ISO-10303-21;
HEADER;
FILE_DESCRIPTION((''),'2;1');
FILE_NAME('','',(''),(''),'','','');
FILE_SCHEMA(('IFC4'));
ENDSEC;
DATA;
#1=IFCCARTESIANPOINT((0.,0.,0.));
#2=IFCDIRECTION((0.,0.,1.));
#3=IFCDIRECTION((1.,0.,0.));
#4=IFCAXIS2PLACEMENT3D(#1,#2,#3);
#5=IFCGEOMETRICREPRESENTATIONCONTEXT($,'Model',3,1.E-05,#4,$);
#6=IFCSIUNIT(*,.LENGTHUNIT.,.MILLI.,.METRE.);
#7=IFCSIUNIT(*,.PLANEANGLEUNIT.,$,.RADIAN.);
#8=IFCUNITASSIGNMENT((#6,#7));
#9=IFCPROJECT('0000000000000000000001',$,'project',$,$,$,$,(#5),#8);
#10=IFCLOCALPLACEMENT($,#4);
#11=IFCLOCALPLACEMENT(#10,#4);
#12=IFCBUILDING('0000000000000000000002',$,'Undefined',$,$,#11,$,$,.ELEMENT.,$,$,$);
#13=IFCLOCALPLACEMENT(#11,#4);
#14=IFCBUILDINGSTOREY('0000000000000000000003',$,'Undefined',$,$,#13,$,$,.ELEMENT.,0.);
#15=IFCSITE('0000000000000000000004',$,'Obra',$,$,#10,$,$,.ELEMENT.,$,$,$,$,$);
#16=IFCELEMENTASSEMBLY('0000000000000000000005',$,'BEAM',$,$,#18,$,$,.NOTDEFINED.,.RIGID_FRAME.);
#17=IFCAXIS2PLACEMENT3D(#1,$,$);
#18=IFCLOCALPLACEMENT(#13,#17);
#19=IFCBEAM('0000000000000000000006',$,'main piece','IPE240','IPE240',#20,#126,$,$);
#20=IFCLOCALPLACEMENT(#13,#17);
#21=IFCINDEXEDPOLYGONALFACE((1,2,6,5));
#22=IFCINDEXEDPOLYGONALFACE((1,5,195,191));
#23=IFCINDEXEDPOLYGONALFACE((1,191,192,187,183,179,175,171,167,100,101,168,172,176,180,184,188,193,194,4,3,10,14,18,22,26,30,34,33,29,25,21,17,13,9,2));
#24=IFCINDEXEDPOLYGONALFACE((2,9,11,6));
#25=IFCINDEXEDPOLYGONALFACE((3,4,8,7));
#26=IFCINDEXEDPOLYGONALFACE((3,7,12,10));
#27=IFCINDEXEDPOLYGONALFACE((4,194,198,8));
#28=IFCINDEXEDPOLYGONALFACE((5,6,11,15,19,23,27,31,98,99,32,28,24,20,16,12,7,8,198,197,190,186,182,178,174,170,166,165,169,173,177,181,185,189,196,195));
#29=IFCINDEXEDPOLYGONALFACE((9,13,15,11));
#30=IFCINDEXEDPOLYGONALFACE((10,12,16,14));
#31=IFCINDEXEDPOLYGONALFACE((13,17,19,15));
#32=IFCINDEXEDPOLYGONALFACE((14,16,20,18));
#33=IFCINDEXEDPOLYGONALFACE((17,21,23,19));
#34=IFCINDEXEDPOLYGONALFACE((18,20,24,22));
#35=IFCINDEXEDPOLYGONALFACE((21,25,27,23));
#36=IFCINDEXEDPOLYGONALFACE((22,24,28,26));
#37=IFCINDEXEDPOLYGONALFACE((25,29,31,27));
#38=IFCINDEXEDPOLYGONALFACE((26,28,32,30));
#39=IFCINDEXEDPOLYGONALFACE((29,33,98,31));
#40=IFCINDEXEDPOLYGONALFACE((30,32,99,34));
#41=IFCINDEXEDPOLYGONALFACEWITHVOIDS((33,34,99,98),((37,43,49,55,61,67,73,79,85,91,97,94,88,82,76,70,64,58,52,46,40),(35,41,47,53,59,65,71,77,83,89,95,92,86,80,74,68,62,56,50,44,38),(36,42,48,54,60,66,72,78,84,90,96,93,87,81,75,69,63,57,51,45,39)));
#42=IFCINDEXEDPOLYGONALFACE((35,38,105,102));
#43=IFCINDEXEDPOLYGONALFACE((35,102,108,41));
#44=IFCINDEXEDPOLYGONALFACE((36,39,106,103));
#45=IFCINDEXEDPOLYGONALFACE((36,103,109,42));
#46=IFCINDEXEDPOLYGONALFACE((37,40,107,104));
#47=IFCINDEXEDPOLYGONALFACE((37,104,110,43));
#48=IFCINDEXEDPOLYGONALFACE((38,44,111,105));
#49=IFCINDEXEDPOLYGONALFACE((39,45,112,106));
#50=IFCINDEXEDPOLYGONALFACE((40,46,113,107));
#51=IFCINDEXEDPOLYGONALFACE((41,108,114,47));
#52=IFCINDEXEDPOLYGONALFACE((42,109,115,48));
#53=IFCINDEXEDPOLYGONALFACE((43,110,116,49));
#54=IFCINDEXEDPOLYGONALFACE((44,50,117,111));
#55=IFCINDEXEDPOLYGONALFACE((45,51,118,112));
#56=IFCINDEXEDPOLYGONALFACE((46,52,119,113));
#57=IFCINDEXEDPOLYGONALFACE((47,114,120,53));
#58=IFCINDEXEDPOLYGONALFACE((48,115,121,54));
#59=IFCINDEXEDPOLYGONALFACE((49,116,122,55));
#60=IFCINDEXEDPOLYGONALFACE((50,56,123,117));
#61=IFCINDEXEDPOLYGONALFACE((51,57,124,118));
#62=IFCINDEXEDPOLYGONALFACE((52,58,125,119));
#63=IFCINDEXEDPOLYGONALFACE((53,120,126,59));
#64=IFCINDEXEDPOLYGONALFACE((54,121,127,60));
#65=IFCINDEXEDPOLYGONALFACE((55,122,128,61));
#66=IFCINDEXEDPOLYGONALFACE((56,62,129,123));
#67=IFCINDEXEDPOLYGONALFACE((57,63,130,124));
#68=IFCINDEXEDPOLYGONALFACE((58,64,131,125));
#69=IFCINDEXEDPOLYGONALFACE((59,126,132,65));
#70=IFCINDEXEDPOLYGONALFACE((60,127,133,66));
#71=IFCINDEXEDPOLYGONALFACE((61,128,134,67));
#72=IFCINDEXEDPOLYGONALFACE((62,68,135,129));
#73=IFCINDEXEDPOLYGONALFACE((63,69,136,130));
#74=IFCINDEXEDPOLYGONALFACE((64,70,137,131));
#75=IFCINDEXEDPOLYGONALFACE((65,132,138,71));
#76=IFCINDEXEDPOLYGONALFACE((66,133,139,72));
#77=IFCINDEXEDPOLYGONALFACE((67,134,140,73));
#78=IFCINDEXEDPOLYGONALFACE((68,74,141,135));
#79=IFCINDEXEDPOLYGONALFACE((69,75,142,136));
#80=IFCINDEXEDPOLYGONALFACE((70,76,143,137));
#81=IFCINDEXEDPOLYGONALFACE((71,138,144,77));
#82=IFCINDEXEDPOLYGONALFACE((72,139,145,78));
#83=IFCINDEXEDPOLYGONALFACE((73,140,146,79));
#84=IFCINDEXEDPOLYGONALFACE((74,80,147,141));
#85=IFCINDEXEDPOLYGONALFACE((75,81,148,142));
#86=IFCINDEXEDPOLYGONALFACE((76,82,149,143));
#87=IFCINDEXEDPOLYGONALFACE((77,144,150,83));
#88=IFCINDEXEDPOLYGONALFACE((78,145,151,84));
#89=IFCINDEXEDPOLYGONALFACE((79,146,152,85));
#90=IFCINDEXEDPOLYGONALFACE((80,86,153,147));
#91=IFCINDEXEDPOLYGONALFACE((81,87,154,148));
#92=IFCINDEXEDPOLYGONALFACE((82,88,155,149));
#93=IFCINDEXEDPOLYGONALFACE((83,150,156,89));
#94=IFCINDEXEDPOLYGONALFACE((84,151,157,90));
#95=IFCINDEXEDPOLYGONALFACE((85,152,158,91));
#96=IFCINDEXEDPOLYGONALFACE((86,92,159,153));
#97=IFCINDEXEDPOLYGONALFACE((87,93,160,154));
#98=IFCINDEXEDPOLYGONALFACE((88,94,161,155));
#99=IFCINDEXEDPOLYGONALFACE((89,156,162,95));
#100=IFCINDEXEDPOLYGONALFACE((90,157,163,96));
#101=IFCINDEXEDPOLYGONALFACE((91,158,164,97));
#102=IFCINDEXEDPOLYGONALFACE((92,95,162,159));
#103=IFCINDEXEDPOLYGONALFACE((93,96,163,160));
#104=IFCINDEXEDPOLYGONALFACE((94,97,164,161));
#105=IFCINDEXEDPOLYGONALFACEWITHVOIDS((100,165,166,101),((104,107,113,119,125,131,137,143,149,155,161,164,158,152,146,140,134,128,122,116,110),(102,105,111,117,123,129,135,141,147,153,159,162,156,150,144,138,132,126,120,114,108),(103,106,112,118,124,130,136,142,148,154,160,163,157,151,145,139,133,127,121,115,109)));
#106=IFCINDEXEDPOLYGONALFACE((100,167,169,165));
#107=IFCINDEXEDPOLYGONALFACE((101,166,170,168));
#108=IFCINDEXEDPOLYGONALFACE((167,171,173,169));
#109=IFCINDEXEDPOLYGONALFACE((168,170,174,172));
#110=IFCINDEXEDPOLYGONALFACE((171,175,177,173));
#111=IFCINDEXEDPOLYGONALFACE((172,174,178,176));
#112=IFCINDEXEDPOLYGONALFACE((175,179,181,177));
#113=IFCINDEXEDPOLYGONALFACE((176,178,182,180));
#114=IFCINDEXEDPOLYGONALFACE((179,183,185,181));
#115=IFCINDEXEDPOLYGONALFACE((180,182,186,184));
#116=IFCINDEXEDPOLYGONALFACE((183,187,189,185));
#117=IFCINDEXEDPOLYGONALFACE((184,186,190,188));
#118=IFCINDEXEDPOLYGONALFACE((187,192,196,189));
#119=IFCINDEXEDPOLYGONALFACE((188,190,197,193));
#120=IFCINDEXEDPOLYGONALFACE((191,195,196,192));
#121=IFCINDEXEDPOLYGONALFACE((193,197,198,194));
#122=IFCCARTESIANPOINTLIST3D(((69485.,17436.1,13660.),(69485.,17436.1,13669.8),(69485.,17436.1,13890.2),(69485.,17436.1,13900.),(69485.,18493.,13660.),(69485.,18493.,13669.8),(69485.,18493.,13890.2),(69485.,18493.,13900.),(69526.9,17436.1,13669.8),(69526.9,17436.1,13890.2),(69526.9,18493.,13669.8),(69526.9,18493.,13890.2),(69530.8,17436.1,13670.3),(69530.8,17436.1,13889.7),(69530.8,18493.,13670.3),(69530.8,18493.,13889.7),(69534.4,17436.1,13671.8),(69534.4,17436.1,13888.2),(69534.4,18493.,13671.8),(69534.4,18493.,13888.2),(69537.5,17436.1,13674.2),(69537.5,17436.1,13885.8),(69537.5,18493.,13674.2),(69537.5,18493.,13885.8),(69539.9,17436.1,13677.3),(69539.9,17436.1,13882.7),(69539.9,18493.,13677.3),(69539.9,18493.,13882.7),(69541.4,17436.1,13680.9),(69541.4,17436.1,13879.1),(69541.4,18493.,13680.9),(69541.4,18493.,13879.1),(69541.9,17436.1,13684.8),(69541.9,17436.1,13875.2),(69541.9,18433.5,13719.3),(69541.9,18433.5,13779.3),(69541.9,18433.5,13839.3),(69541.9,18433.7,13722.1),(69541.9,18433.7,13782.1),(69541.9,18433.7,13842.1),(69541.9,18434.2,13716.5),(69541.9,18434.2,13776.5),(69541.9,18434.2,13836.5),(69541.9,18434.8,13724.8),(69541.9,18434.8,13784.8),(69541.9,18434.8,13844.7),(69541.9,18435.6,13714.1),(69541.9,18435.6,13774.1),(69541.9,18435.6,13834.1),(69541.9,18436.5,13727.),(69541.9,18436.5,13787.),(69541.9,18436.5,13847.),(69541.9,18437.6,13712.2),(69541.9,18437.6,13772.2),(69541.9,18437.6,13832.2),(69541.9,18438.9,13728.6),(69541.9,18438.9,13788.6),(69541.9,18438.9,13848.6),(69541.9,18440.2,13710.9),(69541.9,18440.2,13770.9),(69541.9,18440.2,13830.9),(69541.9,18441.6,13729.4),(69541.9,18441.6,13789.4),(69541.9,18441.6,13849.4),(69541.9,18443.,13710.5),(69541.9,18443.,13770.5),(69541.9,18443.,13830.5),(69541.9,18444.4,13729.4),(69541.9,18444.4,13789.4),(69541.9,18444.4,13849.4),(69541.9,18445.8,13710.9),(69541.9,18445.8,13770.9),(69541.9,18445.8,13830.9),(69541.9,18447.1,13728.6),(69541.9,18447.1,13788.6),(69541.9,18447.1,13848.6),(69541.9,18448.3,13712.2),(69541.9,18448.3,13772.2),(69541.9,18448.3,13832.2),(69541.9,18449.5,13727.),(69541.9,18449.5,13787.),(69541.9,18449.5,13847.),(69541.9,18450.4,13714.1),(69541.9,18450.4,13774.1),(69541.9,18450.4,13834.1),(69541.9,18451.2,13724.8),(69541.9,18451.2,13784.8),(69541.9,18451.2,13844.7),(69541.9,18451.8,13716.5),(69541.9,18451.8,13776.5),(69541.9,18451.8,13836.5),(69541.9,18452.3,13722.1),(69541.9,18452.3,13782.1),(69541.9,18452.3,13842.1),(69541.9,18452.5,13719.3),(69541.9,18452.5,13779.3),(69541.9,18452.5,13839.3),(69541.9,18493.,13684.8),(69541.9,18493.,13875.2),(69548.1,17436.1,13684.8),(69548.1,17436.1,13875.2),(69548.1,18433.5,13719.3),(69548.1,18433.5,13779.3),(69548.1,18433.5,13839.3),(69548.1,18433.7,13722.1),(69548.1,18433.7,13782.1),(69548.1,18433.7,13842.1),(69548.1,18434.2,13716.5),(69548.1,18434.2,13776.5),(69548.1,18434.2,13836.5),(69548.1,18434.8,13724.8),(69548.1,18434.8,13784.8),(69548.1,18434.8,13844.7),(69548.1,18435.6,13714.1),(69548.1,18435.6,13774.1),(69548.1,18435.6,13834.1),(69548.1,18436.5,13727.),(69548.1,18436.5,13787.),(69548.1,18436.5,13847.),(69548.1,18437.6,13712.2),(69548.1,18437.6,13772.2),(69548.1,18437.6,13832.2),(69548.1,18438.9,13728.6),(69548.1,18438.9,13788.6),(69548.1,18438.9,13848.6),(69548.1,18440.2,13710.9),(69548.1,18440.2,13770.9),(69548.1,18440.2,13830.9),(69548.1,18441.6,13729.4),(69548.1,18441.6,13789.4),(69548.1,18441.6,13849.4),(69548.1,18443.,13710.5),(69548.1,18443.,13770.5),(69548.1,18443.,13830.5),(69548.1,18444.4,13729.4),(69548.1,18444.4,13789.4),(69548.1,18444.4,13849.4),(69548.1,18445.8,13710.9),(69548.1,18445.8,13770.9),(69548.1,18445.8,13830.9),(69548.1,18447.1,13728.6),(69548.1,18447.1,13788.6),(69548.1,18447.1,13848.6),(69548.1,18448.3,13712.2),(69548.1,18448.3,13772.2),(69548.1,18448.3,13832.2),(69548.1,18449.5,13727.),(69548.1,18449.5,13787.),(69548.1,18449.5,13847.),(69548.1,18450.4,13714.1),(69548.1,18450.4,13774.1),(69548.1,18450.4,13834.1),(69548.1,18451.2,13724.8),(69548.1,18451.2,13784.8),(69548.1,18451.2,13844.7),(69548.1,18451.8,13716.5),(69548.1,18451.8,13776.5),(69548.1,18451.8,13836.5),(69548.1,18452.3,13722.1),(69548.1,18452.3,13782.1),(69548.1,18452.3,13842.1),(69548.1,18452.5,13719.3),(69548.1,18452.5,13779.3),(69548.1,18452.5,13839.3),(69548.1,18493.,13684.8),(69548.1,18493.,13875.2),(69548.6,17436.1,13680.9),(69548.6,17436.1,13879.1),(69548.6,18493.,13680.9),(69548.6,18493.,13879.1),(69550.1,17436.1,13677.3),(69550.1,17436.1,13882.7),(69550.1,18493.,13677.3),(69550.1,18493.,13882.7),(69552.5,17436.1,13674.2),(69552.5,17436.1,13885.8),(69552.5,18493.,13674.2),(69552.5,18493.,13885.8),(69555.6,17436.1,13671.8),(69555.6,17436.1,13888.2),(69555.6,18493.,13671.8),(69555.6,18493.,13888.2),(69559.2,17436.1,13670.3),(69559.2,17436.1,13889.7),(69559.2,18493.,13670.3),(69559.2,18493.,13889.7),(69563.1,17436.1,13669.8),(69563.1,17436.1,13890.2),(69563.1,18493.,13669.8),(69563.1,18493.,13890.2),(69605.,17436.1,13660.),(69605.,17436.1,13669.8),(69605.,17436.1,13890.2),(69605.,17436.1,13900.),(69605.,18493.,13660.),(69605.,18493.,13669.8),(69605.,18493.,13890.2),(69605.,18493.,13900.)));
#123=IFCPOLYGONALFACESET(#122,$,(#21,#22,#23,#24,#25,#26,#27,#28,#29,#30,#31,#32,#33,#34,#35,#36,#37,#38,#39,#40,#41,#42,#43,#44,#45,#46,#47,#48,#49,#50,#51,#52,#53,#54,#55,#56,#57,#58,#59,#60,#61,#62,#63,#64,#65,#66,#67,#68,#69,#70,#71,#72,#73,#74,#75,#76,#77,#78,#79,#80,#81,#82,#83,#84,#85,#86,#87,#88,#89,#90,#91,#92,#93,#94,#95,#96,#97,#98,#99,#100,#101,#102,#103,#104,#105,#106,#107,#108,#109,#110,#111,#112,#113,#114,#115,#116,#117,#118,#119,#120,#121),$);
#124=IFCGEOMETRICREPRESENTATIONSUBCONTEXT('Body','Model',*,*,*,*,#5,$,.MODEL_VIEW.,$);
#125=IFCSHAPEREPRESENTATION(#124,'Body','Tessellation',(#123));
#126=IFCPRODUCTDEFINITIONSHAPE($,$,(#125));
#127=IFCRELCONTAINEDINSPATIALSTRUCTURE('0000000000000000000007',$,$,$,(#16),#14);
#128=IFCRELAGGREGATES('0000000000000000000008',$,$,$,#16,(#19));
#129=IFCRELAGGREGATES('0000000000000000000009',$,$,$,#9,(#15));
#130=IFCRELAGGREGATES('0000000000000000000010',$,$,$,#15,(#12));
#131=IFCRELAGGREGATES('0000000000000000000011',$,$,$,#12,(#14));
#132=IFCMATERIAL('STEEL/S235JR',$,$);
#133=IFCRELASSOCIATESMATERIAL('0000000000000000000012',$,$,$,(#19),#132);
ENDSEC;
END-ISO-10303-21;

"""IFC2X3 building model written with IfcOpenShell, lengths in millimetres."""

from ifc_helpers import new_model, si_unit, frame, origin_with_axes, origin_2d_with_axis, place, context, subcontext, project, spatial, rectangle, circle, i_section, extrude, clip, halfspace, source, transform, mapped, material, element, aggregate, save


model = new_model("IFC2X3")

# Units and contexts
model_context = context("Model", 3, precision=1e-05, world=origin_with_axes())
body_context = subcontext(model_context, "Body", "Model", "MODEL_VIEW")
ifc_project = project(units=[si_unit("LENGTHUNIT", "METRE", prefix="MILLI"), si_unit("PLANEANGLEUNIT", "RADIAN")], contexts=[model_context])

# Site, building, storey
site_placement = place(None, origin_with_axes())
site = spatial("IfcSite", under=ifc_project, at=site_placement, Name="Obra", CompositionType="ELEMENT")
building_placement = place(site_placement, origin_with_axes())
building = spatial("IfcBuilding", under=site, at=building_placement, Name="Undefined", CompositionType="ELEMENT")
storey_placement = place(building_placement, origin_with_axes())
storey = spatial("IfcBuildingStorey", under=building, at=storey_placement, Name="Undefined", CompositionType="ELEMENT", Elevation=0.0)

# Element assembly, beam, openings
ifc_material_1 = material(Name="STEEL/S235JR")
shared_shape_1 = source(origin_with_axes(), body_context, "Body", "SweptSolid", [
    extrude(circle(Radius=9.5, at=origin_2d_with_axis()), frame((0.0, -3.2, 0.0), z_axis=(0.0, 1.0, 0.0), x_axis=(1.0, 0.0, 0.0)), (0.0, 0.0, 1.0), 6.4),
])
assembly_1_placement = place(storey_placement, origin_with_axes())
assembly_1 = element("IfcElementAssembly", 1, at=assembly_1_placement, inside=storey, Name="BEAM", AssemblyPlace="NOTDEFINED", PredefinedType="RIGID_FRAME")
beam_1_placement = place(assembly_1_placement, frame((69545.0, 17345.4, 13780.0), z_axis=(0.0, 0.0, 1.0), x_axis=(0.0, 1.0, 0.0)))
beam_1 = element("IfcBeam", 2, at=beam_1_placement, material=ifc_material_1, Name="main piece", Description="IPE240", ObjectType="IPE240", context=body_context, shape_type="Clipping", body=[
    clip(clip(extrude(i_section(OverallWidth=120.0, OverallDepth=240.0, WebThickness=6.2, FlangeThickness=9.8, FilletRadius=15.0, at=origin_2d_with_axis()), frame((1147.6, 0.0, 0.0), z_axis=(-1.0, 0.0, 0.0), x_axis=(0.0, -1.0, 0.0)), (0.0, 0.0, 1.0), 1147.6), halfspace(frame((90.8, 60.0, -120.0), z_axis=(-1.0, 0.0, 0.0), x_axis=(0.0, 0.0, 1.0)), False)), halfspace(frame((1147.6, 0.0, -220.0), z_axis=(-1.0, -0.000001, 0.0), x_axis=(-0.000001, 1.0, 0.0)), True)),
])
opening_1_placement = place(assembly_1_placement, frame((69545.0, 17345.4, 13780.0), z_axis=(0.0, 0.0, 1.0), x_axis=(0.0, 1.0, 0.0)))
element("IfcOpeningElement", 3, at=opening_1_placement, cuts=beam_1, ObjectType="Recess", context=body_context, shape_type="SweptSolid", body=[
    extrude(rectangle(XDim=25.8, YDim=68.9, at=origin_2d_with_axis()), frame((1182.1, 61.0, -108.1), z_axis=(0.000001, -1.0, 0.0), x_axis=(0.0, 0.0, -1.0)), (0.0, 0.0, 1.0), 122.0),
])
opening_2_placement = place(assembly_1_placement, frame((69545.0, 17345.4, 13780.0), z_axis=(0.0, 0.0, 1.0), x_axis=(0.0, 1.0, 0.0)))
element("IfcOpeningElement", 4, at=opening_2_placement, cuts=beam_1, ObjectType="Recess", context=body_context, shape_type="SweptSolid", body=[
    extrude(rectangle(XDim=25.8, YDim=68.9, at=origin_2d_with_axis()), frame((1182.1, 61.0, 108.1), z_axis=(0.000001, -1.0, 0.0), x_axis=(0.0, 0.0, -1.0)), (0.0, 0.0, 1.0), 122.0),
])
opening_3_placement = place(assembly_1_placement, frame((69545.0, 18493.0, 13890.2), z_axis=(0.000001, -1.0, 0.0), x_axis=(0.0, 0.0, -1.0)))
element("IfcOpeningElement", 5, at=opening_3_placement, cuts=beam_1, ObjectType="Opening", context=body_context, shape_type="MappedRepresentation", body=[
    mapped(shared_shape_1, transform((170.2, 0.0, 50.0))),
    mapped(shared_shape_1, transform((110.2, 0.0, 50.0))),
    mapped(shared_shape_1, transform((50.2, 0.0, 50.0))),
])

aggregate(assembly_1, [beam_1])

save(model, "model.ifc")
